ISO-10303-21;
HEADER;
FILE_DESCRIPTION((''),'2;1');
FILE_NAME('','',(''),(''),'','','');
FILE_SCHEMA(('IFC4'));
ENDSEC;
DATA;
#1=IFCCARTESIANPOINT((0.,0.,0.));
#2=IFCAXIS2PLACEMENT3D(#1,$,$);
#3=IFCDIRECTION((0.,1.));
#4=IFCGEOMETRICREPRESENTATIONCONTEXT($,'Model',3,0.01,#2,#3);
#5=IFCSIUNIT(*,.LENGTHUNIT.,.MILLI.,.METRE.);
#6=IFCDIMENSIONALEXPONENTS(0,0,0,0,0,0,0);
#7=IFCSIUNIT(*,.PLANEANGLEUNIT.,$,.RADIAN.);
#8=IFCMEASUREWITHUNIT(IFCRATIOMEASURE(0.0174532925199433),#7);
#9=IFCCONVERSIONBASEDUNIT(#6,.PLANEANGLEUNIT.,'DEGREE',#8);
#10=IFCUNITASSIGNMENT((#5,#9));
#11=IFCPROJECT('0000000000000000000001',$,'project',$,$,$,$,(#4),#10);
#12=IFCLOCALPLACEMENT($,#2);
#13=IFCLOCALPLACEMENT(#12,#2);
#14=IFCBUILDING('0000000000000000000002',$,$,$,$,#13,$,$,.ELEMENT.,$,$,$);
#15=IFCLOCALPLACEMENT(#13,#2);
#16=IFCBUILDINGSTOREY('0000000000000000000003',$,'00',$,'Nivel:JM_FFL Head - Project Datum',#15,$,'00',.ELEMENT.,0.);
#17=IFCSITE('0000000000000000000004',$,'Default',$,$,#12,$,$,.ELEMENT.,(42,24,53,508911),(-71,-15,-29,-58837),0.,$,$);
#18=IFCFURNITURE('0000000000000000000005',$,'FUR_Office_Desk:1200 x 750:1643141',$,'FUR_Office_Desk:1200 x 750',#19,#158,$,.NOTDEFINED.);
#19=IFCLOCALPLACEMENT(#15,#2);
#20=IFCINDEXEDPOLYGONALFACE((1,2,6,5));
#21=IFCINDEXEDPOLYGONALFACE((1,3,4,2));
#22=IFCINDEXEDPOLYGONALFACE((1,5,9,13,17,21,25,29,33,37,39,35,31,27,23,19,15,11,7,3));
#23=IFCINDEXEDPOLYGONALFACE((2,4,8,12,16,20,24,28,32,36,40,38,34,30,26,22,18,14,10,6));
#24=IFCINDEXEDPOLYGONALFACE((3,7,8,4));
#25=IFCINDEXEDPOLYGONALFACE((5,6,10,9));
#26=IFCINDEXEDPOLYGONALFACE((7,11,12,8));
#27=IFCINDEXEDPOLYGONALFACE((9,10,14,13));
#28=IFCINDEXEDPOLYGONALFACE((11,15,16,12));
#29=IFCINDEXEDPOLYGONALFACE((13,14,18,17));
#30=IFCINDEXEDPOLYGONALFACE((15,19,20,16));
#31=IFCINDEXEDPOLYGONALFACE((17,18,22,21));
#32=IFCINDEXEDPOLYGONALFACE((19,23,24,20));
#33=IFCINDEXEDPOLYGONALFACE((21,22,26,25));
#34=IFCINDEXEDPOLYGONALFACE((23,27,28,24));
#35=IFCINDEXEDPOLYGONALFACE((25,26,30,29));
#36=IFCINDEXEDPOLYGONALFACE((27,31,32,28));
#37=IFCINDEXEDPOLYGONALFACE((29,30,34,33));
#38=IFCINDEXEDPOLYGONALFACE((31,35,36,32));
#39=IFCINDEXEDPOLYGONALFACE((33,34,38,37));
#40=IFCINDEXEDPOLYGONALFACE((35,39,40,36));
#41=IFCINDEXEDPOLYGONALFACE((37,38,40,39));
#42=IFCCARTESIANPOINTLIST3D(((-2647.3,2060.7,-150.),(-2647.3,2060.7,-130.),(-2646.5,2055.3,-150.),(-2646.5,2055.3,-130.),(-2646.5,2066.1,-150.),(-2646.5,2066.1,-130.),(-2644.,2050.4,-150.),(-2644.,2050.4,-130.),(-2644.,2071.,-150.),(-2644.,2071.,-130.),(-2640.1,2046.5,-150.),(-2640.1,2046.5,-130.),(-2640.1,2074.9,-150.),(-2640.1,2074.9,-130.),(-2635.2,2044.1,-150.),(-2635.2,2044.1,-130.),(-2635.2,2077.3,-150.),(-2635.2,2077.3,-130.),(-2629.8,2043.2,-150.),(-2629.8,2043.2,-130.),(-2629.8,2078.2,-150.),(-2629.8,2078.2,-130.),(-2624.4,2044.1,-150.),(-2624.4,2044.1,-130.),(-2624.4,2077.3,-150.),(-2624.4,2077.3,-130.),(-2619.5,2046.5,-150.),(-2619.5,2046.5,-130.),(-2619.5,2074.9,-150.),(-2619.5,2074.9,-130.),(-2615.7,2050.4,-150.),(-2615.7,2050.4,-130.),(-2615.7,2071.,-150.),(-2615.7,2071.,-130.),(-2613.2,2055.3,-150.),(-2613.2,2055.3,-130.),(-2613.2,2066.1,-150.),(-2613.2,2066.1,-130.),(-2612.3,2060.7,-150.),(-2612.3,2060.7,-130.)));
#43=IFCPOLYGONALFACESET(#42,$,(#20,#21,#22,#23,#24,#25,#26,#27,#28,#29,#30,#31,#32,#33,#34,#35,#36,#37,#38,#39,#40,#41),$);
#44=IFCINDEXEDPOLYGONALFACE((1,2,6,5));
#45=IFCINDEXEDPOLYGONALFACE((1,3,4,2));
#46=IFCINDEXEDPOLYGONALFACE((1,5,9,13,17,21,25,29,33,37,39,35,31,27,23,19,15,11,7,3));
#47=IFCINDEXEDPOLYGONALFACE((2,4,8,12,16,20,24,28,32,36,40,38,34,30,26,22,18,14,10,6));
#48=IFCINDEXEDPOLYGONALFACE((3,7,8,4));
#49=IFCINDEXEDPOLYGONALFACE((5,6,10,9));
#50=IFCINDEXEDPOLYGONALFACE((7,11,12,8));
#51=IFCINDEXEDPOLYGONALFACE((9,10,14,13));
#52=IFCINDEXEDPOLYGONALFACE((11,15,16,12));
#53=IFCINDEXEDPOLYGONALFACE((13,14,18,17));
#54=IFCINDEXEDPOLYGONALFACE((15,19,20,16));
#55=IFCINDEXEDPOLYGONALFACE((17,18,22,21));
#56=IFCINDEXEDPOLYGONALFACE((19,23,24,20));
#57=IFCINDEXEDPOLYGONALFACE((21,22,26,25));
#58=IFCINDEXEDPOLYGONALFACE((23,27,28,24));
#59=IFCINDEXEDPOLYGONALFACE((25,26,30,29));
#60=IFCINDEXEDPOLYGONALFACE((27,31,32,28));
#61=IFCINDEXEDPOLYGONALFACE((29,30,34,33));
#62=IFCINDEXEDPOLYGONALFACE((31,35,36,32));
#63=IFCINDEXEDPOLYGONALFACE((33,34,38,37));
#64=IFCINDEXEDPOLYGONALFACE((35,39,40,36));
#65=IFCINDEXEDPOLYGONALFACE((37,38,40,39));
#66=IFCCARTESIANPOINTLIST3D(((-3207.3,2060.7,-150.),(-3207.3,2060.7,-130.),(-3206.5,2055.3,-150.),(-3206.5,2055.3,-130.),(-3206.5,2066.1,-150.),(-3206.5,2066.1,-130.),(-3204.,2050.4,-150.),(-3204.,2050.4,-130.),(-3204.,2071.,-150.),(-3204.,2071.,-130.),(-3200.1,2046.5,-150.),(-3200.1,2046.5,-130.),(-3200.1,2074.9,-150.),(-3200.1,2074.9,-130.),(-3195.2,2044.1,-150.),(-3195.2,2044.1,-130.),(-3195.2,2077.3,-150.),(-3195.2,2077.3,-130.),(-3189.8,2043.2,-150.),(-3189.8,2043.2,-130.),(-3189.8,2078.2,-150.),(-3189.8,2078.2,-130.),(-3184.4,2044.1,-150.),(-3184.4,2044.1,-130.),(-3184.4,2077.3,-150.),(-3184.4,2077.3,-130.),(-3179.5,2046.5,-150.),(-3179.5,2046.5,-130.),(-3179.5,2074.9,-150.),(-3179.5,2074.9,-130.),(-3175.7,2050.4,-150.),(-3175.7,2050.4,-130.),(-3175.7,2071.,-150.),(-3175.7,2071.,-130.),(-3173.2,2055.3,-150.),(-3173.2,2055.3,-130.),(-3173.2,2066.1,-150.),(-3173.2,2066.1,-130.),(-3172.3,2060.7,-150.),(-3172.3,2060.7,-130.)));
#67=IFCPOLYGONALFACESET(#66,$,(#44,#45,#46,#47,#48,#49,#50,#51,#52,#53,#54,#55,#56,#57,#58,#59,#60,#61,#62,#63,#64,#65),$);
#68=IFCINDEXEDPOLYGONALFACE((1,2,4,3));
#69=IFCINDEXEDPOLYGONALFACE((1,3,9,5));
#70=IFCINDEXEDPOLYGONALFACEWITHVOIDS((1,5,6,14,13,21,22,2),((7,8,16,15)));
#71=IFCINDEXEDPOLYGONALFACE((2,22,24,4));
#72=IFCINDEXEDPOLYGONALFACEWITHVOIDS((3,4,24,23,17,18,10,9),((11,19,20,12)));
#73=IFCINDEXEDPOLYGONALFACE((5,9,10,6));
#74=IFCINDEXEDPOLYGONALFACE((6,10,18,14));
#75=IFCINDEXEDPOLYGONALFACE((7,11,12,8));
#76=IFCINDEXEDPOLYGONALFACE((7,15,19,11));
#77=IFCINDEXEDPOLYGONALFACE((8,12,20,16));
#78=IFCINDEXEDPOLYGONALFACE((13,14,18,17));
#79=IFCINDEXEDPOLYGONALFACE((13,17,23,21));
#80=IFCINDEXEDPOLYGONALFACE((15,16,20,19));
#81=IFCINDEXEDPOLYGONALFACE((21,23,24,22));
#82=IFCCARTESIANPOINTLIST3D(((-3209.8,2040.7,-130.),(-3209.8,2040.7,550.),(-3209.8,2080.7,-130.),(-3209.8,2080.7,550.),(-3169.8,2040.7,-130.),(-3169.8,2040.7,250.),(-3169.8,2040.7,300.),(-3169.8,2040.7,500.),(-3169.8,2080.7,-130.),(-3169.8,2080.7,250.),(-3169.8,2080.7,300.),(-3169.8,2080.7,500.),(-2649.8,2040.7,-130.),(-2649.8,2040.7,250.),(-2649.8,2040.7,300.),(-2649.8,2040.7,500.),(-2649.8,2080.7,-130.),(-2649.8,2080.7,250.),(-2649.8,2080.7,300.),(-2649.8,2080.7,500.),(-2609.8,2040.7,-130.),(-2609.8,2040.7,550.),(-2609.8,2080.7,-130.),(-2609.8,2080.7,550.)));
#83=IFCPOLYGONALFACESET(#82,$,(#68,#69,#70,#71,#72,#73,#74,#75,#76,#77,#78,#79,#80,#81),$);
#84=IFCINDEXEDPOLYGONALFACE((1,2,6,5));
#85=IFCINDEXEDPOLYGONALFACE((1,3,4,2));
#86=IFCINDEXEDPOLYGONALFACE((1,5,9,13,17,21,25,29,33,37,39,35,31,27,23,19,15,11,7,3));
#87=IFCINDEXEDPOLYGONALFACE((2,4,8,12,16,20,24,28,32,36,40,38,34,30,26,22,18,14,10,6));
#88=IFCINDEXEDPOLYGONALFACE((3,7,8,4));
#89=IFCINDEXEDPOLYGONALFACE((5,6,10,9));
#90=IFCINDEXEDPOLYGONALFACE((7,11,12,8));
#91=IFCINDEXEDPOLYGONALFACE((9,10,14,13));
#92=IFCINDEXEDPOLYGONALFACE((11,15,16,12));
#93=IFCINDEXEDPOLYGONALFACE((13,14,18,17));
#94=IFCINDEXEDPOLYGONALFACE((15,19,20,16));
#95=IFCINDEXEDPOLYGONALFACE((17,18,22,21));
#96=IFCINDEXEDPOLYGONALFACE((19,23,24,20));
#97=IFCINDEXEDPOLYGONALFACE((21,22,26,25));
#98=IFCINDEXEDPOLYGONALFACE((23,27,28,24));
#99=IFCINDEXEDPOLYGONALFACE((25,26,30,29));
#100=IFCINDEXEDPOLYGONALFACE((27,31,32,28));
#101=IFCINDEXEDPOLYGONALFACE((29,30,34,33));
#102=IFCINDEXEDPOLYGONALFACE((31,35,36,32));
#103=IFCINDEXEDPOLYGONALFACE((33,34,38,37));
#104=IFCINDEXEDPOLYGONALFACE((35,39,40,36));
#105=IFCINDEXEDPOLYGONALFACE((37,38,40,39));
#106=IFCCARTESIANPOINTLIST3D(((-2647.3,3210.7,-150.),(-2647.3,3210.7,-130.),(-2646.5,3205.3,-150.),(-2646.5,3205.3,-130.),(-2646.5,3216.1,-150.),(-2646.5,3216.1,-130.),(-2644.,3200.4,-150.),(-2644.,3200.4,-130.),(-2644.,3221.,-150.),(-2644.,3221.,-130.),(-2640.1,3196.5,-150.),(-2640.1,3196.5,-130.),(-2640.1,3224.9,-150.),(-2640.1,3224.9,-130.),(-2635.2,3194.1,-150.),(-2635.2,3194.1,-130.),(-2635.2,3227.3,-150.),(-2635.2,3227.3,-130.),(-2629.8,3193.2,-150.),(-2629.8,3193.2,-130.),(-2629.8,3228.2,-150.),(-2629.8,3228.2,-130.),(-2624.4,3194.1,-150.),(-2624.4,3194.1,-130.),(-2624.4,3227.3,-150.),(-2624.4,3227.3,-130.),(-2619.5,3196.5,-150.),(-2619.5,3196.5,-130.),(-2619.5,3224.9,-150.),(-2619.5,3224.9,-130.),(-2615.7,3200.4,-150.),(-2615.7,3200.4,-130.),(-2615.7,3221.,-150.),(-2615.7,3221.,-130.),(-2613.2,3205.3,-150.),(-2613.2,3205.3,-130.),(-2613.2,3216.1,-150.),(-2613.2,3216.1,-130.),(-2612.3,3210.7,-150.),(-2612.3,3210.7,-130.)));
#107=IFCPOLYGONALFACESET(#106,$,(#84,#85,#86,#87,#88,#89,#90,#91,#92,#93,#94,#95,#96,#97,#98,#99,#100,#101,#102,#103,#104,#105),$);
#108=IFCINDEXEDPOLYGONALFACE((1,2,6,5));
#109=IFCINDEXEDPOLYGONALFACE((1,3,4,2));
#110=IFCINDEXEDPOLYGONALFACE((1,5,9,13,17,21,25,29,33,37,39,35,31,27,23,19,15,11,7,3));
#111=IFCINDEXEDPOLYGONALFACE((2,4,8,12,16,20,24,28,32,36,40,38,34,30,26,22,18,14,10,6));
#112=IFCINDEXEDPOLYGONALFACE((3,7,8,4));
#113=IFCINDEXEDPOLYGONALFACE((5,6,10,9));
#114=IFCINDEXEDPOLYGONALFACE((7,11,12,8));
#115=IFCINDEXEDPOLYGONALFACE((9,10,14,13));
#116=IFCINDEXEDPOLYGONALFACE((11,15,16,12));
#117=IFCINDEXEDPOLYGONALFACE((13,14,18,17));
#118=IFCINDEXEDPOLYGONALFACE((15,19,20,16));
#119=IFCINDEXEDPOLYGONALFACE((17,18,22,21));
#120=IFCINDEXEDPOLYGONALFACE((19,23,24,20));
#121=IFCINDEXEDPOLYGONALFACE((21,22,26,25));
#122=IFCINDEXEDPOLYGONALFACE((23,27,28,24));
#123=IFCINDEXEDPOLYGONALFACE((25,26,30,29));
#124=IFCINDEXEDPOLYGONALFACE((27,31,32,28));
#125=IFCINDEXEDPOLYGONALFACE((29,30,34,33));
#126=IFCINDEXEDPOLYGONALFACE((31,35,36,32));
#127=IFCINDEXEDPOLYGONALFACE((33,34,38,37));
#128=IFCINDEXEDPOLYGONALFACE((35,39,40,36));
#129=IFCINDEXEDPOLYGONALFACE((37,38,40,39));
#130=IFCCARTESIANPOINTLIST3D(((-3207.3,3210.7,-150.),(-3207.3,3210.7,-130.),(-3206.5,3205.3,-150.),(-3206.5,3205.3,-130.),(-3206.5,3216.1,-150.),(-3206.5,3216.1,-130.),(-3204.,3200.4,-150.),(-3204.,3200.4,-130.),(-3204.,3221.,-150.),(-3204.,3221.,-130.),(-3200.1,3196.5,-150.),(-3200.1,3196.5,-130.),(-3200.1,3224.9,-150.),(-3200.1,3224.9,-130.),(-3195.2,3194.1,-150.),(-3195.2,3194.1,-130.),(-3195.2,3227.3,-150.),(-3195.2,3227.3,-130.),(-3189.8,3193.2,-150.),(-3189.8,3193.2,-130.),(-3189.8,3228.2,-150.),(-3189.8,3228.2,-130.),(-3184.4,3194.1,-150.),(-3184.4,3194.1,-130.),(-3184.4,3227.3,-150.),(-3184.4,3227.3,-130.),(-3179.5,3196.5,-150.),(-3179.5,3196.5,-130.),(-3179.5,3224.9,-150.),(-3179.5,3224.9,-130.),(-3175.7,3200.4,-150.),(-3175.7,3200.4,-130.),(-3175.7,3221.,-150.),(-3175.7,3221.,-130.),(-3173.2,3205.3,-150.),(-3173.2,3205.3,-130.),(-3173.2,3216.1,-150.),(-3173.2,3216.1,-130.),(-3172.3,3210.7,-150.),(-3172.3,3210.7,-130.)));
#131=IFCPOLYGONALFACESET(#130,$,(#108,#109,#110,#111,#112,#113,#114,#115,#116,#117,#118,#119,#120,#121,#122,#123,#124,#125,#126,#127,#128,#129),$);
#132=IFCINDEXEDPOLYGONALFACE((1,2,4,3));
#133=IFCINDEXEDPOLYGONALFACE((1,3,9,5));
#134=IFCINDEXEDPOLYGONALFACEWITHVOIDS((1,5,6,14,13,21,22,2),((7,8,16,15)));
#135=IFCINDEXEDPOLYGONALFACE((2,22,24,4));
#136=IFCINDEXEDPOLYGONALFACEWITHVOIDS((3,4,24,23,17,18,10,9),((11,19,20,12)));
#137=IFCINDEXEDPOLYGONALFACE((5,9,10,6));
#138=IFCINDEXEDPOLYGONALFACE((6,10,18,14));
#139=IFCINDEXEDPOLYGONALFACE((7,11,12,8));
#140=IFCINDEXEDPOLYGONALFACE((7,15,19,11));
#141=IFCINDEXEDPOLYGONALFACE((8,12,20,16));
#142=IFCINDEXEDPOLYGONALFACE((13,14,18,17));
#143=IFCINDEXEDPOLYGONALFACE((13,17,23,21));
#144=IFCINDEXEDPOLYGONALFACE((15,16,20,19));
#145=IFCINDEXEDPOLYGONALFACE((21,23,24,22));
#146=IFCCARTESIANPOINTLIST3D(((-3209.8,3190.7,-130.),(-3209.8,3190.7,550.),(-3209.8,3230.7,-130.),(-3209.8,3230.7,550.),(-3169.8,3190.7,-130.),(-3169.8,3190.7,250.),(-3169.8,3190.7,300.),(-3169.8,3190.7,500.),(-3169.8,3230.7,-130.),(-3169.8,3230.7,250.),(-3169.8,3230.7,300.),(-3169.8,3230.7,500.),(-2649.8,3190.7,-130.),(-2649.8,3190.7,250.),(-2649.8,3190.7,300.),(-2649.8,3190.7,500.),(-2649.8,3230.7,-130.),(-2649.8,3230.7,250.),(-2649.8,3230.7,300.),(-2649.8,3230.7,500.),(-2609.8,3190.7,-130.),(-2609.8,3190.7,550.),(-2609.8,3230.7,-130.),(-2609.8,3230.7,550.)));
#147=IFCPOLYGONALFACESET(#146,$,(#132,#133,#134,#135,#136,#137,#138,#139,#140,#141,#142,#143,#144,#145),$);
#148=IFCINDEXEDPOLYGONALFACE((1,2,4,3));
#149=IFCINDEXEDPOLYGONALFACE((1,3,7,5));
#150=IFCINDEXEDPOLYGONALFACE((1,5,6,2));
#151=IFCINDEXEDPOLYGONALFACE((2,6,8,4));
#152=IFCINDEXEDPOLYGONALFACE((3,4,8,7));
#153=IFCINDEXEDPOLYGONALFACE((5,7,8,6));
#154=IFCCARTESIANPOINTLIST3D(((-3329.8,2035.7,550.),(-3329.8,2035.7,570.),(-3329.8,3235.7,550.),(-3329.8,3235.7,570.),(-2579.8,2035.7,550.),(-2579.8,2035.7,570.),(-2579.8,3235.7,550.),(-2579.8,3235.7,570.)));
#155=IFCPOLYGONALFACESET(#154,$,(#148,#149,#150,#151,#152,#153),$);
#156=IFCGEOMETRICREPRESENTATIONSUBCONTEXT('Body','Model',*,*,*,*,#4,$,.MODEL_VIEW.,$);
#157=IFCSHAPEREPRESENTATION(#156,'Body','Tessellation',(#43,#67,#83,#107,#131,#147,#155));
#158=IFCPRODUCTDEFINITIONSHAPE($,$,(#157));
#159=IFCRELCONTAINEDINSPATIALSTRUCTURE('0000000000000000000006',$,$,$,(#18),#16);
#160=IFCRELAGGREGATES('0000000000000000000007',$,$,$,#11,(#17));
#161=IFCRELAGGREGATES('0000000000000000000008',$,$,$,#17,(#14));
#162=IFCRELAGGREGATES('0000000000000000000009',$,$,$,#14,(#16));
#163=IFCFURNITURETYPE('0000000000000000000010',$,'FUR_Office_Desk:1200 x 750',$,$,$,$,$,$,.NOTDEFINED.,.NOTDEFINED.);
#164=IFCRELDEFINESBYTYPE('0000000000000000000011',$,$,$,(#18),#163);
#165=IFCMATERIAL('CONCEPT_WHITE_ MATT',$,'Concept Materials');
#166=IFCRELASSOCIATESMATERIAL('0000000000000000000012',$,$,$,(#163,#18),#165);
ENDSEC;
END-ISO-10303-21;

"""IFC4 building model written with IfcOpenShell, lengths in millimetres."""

from ifc_helpers import new_model, entity, si_unit, converted_unit, direction, frame, origin, place, context, subcontext, project, spatial, indexed_curve, outline, extrude, source, transform, mapped, material, type_object, type_shapes, element, save


model = new_model("IFC4")

# Units and contexts
model_context = context("Model", 3, precision=0.01, world=origin(), true_north=direction((0.0, 1.0)))
body_context = subcontext(model_context, "Body", "Model", "MODEL_VIEW")
ifc_project = project(units=[si_unit("LENGTHUNIT", "METRE", prefix="MILLI"), converted_unit("PLANEANGLEUNIT", "DEGREE", entity("IfcRatioMeasure", 0.0174532925199433), si_unit("PLANEANGLEUNIT", "RADIAN"), dimensions=[0, 0, 0, 0, 0, 0, 0])], contexts=[model_context])

# Site, building, storey
site_placement = place(None, origin())
site = spatial("IfcSite", under=ifc_project, at=site_placement, Name="Default", CompositionType="ELEMENT", RefLatitude=(42, 24, 53, 508911), RefLongitude=(-71, -15, -29, -58837), RefElevation=0.0)
building_placement = place(site_placement, origin())
building = spatial("IfcBuilding", under=site, at=building_placement, CompositionType="ELEMENT")
storey_placement = place(building_placement, origin())
storey = spatial("IfcBuildingStorey", under=building, at=storey_placement, Name="00", ObjectType="Nivel:JM_FFL Head - Project Datum", LongName="00", CompositionType="ELEMENT", Elevation=0.0)

# Shared definitions
ifc_material_1 = material(Name="CONCEPT_WHITE_ MATT", Category="Concept Materials")

# Furniture
furniture_type_1 = type_object("IfcFurnitureType", Name="FUR_Office_Desk:1200 x 750", AssemblyPlace="NOTDEFINED", PredefinedType="NOTDEFINED", material=ifc_material_1)
shared_shape_1 = source(origin(), body_context, "Body", "SweptSolid", [
    extrude(outline(indexed_curve([(17.5, 0.0), (16.6, 5.4), (14.2, 10.3), (10.3, 14.2), (5.4, 16.6), (0.0, 17.5), (-5.4, 16.6), (-10.3, 14.2), (-14.2, 10.3), (-16.6, 5.4), (-17.5, 0.0), (-16.6, -5.4), (-14.2, -10.3), (-10.3, -14.2), (-5.4, -16.6), (0.0, -17.5), (5.4, -16.6), (10.3, -14.2), (14.2, -10.3), (16.6, -5.4), (17.5, 0.0)], self_intersect=False)), frame((-530.3, -700.0, 0.0)), (0.0, 0.0, 1.0), 20.0),
    extrude(outline(indexed_curve([(17.5, 0.0), (16.6, 5.4), (14.2, 10.3), (10.3, 14.2), (5.4, 16.6), (0.0, 17.5), (-5.4, 16.6), (-10.3, 14.2), (-14.2, 10.3), (-16.6, 5.4), (-17.5, 0.0), (-16.6, -5.4), (-14.2, -10.3), (-10.3, -14.2), (-5.4, -16.6), (0.0, -17.5), (5.4, -16.6), (10.3, -14.2), (14.2, -10.3), (16.6, -5.4), (17.5, 0.0)], self_intersect=False)), frame((-530.3, -140.0, 0.0)), (0.0, 0.0, 1.0), 20.0),
    extrude(outline(indexed_curve([(-265.0, -300.0), (415.0, -300.0), (415.0, 300.0), (-265.0, 300.0), (-265.0, 260.0), (115.0, 260.0), (115.0, -260.0), (-265.0, -260.0), (-265.0, -300.0)], self_intersect=False), holes=[indexed_curve([(165.0, 260.0), (365.0, 260.0), (365.0, -260.0), (165.0, -260.0), (165.0, 260.0)], self_intersect=False)]), frame((-550.3, -420.0, 285.0), z_axis=(1.0, 0.0, 0.0), x_axis=(0.0, 0.0, 1.0)), (0.0, 0.0, 1.0), 40.0),
    extrude(outline(indexed_curve([(17.5, 0.0), (16.6, 5.4), (14.2, 10.3), (10.3, 14.2), (5.4, 16.6), (0.0, 17.5), (-5.4, 16.6), (-10.3, 14.2), (-14.2, 10.3), (-16.6, 5.4), (-17.5, 0.0), (-16.6, -5.4), (-14.2, -10.3), (-10.3, -14.2), (-5.4, -16.6), (0.0, -17.5), (5.4, -16.6), (10.3, -14.2), (14.2, -10.3), (16.6, -5.4), (17.5, 0.0)], self_intersect=False)), frame((619.7, -700.0, 0.0)), (0.0, 0.0, 1.0), 20.0),
    extrude(outline(indexed_curve([(17.5, 0.0), (16.6, 5.4), (14.2, 10.3), (10.3, 14.2), (5.4, 16.6), (0.0, 17.5), (-5.4, 16.6), (-10.3, 14.2), (-14.2, 10.3), (-16.6, 5.4), (-17.5, 0.0), (-16.6, -5.4), (-14.2, -10.3), (-10.3, -14.2), (-5.4, -16.6), (0.0, -17.5), (5.4, -16.6), (10.3, -14.2), (14.2, -10.3), (16.6, -5.4), (17.5, 0.0)], self_intersect=False)), frame((619.7, -140.0, 0.0)), (0.0, 0.0, 1.0), 20.0),
    extrude(outline(indexed_curve([(-265.0, -300.0), (415.0, -300.0), (415.0, 300.0), (-265.0, 300.0), (-265.0, 260.0), (115.0, 260.0), (115.0, -260.0), (-265.0, -260.0), (-265.0, -300.0)], self_intersect=False), holes=[indexed_curve([(165.0, 260.0), (365.0, 260.0), (365.0, -260.0), (165.0, -260.0), (165.0, 260.0)], self_intersect=False)]), frame((599.7, -420.0, 285.0), z_axis=(1.0, 0.0, 0.0), x_axis=(0.0, 0.0, 1.0)), (0.0, 0.0, 1.0), 40.0),
    extrude(outline(indexed_curve([(-600.0, -375.0), (600.0, -375.0), (600.0, 375.0), (-600.0, 375.0), (-600.0, -375.0)], self_intersect=False)), frame((44.7, -375.0, 700.0), z_axis=(0.0, 0.0, 1.0), x_axis=(-1.0, 0.0, 0.0)), (0.0, 0.0, 1.0), 20.0),
])
type_shapes(furniture_type_1, [shared_shape_1])
furniture_1_placement = place(storey_placement, frame((-3329.8, 2591.0, -150.0), z_axis=(0.0, 0.0, 1.0), x_axis=(0.0, 1.0, 0.0)))
element("IfcFurniture", 1, at=furniture_1_placement, inside=storey, type_object=furniture_type_1, material=ifc_material_1, Name="FUR_Office_Desk:1200 x 750:1643141", ObjectType="FUR_Office_Desk:1200 x 750", PredefinedType="NOTDEFINED", context=body_context, shape_type="MappedRepresentation", body=[
    mapped(shared_shape_1, transform((0.0, 0.0, 0.0), scale=1.0)),
])

save(model, "model.ifc")
